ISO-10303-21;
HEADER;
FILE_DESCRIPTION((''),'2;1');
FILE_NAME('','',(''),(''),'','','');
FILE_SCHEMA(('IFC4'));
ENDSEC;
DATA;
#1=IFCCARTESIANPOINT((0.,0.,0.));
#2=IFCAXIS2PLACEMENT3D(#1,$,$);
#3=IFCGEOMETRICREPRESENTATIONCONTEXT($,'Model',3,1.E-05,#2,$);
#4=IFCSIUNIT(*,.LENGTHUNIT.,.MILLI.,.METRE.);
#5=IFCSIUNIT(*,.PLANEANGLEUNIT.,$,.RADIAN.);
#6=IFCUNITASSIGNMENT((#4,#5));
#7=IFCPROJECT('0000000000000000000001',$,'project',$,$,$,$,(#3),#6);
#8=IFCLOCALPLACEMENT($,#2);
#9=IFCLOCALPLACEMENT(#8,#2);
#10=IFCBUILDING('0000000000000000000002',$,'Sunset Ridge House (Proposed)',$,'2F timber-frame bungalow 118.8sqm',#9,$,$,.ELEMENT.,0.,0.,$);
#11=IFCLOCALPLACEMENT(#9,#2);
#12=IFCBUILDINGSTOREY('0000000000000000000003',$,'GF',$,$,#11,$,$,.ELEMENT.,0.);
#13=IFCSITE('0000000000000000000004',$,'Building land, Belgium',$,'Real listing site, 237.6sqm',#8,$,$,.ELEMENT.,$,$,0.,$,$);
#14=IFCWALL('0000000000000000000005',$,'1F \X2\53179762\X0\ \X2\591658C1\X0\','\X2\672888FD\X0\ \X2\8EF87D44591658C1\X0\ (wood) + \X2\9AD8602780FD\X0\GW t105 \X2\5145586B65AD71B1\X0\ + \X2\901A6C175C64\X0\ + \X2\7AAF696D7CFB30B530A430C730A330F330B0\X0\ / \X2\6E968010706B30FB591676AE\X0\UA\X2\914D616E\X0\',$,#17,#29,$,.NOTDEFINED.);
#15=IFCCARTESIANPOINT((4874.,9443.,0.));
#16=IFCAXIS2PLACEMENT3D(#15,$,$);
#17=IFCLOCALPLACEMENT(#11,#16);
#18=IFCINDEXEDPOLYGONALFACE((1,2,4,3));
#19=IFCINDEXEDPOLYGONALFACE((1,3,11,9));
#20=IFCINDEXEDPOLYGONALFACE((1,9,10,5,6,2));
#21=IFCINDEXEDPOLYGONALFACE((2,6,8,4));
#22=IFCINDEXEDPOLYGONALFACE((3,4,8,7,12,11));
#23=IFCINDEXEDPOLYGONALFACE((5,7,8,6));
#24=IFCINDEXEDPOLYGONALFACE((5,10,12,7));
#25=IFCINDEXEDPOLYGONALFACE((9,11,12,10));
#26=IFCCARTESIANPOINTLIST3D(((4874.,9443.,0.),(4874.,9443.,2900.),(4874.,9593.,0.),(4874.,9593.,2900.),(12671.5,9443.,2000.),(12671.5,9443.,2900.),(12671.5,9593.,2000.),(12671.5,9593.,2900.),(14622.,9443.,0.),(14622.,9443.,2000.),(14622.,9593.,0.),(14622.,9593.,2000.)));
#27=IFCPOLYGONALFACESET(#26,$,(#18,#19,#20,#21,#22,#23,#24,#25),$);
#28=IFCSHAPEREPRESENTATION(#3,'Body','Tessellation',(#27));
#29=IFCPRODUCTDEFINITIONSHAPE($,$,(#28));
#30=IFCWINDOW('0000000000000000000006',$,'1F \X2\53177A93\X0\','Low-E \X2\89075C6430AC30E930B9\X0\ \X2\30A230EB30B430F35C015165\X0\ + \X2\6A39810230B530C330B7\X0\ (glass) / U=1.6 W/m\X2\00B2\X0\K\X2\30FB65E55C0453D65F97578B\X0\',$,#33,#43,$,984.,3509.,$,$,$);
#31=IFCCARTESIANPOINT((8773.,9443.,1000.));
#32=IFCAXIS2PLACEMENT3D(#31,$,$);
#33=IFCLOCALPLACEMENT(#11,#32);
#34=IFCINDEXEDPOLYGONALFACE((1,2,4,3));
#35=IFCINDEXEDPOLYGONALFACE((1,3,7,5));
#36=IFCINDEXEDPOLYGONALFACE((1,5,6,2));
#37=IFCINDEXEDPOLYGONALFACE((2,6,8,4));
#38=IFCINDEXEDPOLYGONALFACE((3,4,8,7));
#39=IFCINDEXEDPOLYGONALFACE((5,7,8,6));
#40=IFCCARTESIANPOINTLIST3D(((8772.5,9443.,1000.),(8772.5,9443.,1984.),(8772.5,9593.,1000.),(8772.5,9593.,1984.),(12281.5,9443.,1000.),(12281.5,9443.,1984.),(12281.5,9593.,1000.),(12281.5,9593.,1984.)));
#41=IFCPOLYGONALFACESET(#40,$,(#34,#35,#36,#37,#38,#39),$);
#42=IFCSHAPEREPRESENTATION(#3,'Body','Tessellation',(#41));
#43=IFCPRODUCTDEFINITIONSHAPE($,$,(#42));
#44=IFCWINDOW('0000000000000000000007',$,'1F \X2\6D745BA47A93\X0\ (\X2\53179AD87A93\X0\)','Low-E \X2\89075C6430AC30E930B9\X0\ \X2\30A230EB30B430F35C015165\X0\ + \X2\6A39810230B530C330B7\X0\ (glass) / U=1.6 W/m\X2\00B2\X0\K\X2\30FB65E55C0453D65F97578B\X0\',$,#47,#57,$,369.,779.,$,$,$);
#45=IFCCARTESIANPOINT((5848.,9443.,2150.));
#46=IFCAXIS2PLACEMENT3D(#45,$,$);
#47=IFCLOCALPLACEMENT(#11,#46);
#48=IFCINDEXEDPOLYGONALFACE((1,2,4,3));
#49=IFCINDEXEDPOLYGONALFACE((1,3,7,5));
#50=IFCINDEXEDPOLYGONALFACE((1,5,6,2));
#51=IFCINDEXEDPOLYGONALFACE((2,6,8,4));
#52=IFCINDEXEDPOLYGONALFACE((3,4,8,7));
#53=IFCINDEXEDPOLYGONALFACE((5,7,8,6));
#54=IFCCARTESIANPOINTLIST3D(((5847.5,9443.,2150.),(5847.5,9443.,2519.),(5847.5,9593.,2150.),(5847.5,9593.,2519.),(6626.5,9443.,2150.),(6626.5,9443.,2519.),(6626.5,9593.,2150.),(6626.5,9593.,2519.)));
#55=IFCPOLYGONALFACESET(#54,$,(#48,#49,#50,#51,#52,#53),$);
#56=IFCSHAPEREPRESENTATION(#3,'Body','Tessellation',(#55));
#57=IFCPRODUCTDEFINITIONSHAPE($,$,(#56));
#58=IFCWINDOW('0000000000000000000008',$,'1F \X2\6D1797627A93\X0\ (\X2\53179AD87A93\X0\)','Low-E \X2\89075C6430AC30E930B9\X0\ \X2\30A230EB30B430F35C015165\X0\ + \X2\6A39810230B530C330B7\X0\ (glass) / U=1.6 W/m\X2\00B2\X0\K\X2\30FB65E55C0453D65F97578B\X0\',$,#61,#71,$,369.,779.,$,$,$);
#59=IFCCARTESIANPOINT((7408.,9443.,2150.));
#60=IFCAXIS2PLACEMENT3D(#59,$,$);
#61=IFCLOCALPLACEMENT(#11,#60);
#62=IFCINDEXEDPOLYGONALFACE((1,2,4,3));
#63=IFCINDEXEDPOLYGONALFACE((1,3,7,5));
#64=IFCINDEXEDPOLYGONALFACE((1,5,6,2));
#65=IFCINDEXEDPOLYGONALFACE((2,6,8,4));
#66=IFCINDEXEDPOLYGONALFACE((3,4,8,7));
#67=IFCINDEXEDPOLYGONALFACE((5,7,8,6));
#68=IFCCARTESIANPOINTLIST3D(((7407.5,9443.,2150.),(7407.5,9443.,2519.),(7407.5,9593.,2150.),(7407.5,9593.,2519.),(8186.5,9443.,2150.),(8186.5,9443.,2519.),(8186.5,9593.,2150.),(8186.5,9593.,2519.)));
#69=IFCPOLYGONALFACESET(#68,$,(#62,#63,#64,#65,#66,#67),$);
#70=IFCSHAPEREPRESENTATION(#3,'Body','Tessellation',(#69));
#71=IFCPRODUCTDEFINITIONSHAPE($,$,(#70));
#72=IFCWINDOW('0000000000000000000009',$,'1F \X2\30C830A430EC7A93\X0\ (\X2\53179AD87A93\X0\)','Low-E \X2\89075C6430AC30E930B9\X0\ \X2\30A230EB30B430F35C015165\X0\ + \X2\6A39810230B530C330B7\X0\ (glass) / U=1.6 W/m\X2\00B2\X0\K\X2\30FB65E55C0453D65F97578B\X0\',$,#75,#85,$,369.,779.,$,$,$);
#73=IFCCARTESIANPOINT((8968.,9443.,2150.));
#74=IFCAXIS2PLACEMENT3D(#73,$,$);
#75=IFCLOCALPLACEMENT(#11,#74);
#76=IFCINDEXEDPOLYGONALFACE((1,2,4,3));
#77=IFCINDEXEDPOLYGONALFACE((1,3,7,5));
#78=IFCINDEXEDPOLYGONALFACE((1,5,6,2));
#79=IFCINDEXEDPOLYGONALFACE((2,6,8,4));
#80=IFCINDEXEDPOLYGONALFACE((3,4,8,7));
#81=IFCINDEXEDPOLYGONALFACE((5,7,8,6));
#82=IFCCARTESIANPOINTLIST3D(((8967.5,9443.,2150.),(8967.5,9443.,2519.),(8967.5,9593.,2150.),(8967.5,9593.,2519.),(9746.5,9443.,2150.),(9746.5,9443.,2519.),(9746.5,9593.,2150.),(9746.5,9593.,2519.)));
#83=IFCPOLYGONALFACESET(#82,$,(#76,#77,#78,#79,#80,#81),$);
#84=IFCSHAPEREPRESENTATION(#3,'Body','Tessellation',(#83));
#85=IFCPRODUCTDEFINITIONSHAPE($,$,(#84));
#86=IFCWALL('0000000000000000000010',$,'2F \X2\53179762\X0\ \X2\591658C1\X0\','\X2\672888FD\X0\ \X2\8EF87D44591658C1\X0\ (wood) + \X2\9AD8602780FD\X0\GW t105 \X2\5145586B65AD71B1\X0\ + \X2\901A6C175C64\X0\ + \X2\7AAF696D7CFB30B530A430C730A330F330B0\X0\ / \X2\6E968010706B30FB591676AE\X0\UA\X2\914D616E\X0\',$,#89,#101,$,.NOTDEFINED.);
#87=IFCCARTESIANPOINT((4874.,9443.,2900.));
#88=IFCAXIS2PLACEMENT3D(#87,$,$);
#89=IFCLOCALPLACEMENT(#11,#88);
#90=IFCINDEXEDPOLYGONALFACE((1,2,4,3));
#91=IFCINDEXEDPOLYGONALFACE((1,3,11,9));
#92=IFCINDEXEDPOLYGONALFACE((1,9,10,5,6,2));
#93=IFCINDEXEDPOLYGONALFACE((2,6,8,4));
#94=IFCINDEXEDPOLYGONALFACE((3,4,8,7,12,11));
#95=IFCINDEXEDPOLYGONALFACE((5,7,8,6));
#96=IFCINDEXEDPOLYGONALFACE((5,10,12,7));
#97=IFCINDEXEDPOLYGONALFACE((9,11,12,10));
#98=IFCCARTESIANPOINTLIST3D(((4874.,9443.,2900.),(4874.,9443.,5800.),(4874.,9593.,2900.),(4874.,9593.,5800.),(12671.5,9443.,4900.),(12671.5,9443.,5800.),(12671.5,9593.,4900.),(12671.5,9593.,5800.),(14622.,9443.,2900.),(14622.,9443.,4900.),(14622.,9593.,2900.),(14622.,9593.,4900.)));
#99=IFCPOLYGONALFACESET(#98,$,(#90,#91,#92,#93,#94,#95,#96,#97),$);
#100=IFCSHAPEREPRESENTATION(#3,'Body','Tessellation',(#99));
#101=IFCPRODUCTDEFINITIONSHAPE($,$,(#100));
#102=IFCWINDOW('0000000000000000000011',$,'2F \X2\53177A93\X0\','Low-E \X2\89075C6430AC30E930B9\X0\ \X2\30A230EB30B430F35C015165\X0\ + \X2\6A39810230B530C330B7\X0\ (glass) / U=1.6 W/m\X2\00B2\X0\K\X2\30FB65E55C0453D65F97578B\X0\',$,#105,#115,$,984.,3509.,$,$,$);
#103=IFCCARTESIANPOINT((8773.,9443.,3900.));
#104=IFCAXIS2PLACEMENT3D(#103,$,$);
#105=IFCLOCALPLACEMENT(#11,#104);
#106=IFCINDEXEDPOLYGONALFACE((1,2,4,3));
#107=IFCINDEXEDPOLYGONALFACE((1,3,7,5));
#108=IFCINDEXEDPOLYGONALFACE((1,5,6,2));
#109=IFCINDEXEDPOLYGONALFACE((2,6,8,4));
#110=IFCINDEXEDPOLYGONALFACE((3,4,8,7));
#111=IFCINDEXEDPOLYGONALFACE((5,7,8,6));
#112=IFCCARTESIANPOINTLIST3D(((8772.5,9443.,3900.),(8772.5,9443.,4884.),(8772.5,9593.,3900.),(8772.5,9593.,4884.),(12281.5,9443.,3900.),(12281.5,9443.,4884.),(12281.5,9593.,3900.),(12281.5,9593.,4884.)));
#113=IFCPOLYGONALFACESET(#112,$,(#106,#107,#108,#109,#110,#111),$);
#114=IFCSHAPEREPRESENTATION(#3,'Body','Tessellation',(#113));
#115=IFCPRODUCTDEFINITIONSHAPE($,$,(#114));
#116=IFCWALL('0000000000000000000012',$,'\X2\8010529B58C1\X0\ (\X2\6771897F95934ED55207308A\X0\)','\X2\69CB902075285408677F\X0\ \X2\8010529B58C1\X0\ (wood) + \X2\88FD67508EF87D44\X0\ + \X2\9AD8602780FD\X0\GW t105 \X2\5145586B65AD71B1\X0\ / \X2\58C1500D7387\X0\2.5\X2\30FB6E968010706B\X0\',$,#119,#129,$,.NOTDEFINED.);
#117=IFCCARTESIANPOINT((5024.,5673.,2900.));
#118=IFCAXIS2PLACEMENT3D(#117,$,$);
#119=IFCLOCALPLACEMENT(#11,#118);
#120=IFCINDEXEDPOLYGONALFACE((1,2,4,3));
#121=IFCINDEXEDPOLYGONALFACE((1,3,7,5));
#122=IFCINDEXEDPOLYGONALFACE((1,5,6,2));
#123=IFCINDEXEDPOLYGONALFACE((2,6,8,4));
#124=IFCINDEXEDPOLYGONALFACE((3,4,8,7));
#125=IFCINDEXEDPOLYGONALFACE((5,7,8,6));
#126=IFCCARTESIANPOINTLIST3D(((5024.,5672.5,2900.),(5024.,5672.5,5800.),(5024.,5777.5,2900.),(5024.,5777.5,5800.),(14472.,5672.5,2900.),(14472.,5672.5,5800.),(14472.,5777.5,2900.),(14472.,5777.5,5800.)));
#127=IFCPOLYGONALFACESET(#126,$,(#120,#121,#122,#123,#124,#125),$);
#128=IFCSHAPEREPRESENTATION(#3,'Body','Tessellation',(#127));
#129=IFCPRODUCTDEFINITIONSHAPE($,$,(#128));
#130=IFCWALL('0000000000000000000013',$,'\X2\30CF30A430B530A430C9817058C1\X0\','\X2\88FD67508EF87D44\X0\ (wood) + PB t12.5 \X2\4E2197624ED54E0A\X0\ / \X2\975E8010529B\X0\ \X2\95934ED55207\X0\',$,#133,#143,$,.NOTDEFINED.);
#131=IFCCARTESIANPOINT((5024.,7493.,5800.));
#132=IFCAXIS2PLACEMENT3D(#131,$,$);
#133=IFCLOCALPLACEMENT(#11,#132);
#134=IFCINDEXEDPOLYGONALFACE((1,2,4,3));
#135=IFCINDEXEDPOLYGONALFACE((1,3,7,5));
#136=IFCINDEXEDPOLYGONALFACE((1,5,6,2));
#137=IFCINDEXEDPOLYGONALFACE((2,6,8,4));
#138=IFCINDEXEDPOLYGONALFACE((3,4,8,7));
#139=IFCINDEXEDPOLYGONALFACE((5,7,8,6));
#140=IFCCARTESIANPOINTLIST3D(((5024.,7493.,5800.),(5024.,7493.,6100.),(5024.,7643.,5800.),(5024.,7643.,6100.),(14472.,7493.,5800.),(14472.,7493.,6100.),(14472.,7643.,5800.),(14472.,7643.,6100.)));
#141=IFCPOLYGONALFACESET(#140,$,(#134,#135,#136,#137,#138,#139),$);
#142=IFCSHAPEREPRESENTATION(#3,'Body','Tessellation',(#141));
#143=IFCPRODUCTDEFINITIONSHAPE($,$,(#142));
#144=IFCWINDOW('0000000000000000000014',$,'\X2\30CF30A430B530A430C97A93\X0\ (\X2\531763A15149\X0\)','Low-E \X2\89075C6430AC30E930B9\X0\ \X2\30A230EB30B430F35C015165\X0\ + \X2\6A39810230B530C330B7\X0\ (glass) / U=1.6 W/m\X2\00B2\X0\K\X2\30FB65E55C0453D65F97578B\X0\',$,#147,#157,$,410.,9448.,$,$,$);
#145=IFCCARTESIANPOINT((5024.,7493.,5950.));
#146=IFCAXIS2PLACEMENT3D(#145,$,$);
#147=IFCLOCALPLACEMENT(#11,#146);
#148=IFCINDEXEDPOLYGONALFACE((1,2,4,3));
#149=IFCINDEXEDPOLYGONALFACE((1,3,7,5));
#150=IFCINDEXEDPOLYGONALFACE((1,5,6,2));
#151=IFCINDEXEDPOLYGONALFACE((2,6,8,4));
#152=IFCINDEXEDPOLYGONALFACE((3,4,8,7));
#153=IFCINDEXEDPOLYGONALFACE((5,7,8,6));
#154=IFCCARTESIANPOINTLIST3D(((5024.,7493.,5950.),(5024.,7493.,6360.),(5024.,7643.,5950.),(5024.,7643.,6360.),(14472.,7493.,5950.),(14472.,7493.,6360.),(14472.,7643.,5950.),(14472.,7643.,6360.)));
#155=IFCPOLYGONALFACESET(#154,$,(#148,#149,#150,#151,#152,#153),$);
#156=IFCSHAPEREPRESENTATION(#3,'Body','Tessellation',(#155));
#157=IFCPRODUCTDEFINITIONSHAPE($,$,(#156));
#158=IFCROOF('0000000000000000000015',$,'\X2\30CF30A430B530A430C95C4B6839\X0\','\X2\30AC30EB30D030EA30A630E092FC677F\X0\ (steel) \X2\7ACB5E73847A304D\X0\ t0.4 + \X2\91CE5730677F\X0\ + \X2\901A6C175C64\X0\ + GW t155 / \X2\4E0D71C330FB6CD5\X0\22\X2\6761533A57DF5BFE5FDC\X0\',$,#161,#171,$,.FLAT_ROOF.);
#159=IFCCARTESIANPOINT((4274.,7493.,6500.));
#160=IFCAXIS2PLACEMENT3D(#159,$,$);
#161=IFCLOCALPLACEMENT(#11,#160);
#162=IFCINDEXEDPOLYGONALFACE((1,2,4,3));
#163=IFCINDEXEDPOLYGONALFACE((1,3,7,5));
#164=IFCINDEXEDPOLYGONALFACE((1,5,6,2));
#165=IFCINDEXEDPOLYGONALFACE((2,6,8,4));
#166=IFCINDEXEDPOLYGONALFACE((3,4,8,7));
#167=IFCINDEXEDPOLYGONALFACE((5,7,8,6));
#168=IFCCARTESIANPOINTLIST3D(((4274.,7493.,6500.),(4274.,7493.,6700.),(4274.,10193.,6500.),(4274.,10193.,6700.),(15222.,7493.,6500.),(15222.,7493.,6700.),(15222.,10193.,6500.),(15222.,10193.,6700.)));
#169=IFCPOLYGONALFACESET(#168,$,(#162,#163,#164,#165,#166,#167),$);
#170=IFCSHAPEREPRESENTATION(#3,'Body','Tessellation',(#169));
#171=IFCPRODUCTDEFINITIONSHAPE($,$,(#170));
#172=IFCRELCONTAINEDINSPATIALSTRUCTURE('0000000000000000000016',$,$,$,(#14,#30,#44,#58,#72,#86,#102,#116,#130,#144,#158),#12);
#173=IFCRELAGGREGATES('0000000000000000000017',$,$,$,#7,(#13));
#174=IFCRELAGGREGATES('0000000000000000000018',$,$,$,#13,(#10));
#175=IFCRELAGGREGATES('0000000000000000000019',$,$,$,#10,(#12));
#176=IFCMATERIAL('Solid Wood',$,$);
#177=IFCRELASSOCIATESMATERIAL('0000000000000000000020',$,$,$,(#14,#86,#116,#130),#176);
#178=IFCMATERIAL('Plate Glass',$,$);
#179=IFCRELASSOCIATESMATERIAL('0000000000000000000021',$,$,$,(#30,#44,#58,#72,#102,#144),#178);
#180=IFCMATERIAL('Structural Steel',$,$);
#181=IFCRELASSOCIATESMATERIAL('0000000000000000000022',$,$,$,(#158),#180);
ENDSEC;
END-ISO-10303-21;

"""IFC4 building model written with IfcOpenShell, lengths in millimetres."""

from ifc_helpers import new_model, si_unit, frame, frame_2d, origin, place, context, project, spatial, rectangle, extrude, material, element, fill, save


model = new_model("IFC4")

# Units and contexts
model_context = context("Model", 3, precision=1e-05, world=origin())
ifc_project = project(units=[si_unit("LENGTHUNIT", "METRE", prefix="MILLI"), si_unit("PLANEANGLEUNIT", "RADIAN")], contexts=[model_context])

# Site, building, storey
site_placement = place(None, origin())
site = spatial("IfcSite", under=ifc_project, at=site_placement, Name="Building land, Belgium", ObjectType="Real listing site, 237.6sqm", CompositionType="ELEMENT", RefElevation=0.0)
building_placement = place(site_placement, origin())
building = spatial("IfcBuilding", under=site, at=building_placement, Name="Sunset Ridge House (Proposed)", ObjectType="2F timber-frame bungalow 118.8sqm", CompositionType="ELEMENT", ElevationOfRefHeight=0.0, ElevationOfTerrain=0.0)
storey_placement = place(building_placement, origin())
storey = spatial("IfcBuildingStorey", under=building, at=storey_placement, Name="GF", CompositionType="ELEMENT", Elevation=0.0)

# Wall, openings, windows
ifc_material_1 = material(Name="Solid Wood")
wall_1_placement = place(storey_placement, frame((4874.0, 9443.0, 0.0)))
wall_1 = element("IfcWall", 1, at=wall_1_placement, inside=storey, material=ifc_material_1, Name="1F 北面 外壁", Description="木製 軸組外壁 (wood) + 高性能GW t105 充填断熱 + 通気層 + 窯業系サイディング / 準耐火・外皮UA配慮", PredefinedType="NOTDEFINED", context=model_context, shape_type="SweptSolid", body=[
    extrude(rectangle(XDim=9748.0, YDim=150.0, at=frame_2d((4874.0, 75.0))), frame((4874.0, 9443.0, 0.0)), (0.0, 0.0, 1.0), 2900.0),
])
opening_1_placement = place(storey_placement, frame((8773.0, 9443.0, 1000.0)))
opening_1 = element("IfcOpeningElement", 2, at=opening_1_placement, cuts=wall_1, PredefinedType="NOTDEFINED", context=model_context, shape_type="SweptSolid", body=[
    extrude(rectangle(XDim=3509.0, YDim=150.0, at=frame_2d((1754.0, 75.0))), frame((8773.0, 9443.0, 1000.0)), (0.0, 0.0, 1.0), 984.0),
])
opening_2_placement = place(storey_placement, frame((5848.0, 9443.0, 2150.0)))
opening_2 = element("IfcOpeningElement", 3, at=opening_2_placement, cuts=wall_1, PredefinedType="NOTDEFINED", context=model_context, shape_type="SweptSolid", body=[
    extrude(rectangle(XDim=779.0, YDim=150.0, at=frame_2d((389.0, 75.0))), frame((5848.0, 9443.0, 2150.0)), (0.0, 0.0, 1.0), 369.0),
])
opening_3_placement = place(storey_placement, frame((7408.0, 9443.0, 2150.0)))
opening_3 = element("IfcOpeningElement", 4, at=opening_3_placement, cuts=wall_1, PredefinedType="NOTDEFINED", context=model_context, shape_type="SweptSolid", body=[
    extrude(rectangle(XDim=779.0, YDim=150.0, at=frame_2d((389.0, 75.0))), frame((7408.0, 9443.0, 2150.0)), (0.0, 0.0, 1.0), 369.0),
])
opening_4_placement = place(storey_placement, frame((8968.0, 9443.0, 2150.0)))
opening_4 = element("IfcOpeningElement", 5, at=opening_4_placement, cuts=wall_1, PredefinedType="NOTDEFINED", context=model_context, shape_type="SweptSolid", body=[
    extrude(rectangle(XDim=779.0, YDim=150.0, at=frame_2d((389.0, 75.0))), frame((8968.0, 9443.0, 2150.0)), (0.0, 0.0, 1.0), 369.0),
])
ifc_material_2 = material(Name="Plate Glass")
window_1_placement = place(storey_placement, frame((8773.0, 9443.0, 1000.0)))
window_1 = element("IfcWindow", 6, at=window_1_placement, inside=storey, material=ifc_material_2, Name="1F 北窓", Description="Low-E 複層ガラス アルゴン封入 + 樹脂サッシ (glass) / U=1.6 W/m²K・日射取得型", OverallHeight=984.0, OverallWidth=3509.0, context=model_context, shape_type="SweptSolid", body=[
    extrude(rectangle(XDim=3509.0, YDim=150.0, at=frame_2d((1754.0, 75.0))), frame((8773.0, 9443.0, 1000.0)), (0.0, 0.0, 1.0), 984.0),
])
fill(opening_1, window_1)
window_2_placement = place(storey_placement, frame((5848.0, 9443.0, 2150.0)))
window_2 = element("IfcWindow", 7, at=window_2_placement, inside=storey, material=ifc_material_2, Name="1F 浴室窓 (北高窓)", Description="Low-E 複層ガラス アルゴン封入 + 樹脂サッシ (glass) / U=1.6 W/m²K・日射取得型", OverallHeight=369.0, OverallWidth=779.0, context=model_context, shape_type="SweptSolid", body=[
    extrude(rectangle(XDim=779.0, YDim=150.0, at=frame_2d((389.0, 75.0))), frame((5848.0, 9443.0, 2150.0)), (0.0, 0.0, 1.0), 369.0),
])
fill(opening_2, window_2)
window_3_placement = place(storey_placement, frame((7408.0, 9443.0, 2150.0)))
window_3 = element("IfcWindow", 8, at=window_3_placement, inside=storey, material=ifc_material_2, Name="1F 洗面窓 (北高窓)", Description="Low-E 複層ガラス アルゴン封入 + 樹脂サッシ (glass) / U=1.6 W/m²K・日射取得型", OverallHeight=369.0, OverallWidth=779.0, context=model_context, shape_type="SweptSolid", body=[
    extrude(rectangle(XDim=779.0, YDim=150.0, at=frame_2d((389.0, 75.0))), frame((7408.0, 9443.0, 2150.0)), (0.0, 0.0, 1.0), 369.0),
])
fill(opening_3, window_3)
window_4_placement = place(storey_placement, frame((8968.0, 9443.0, 2150.0)))
window_4 = element("IfcWindow", 9, at=window_4_placement, inside=storey, material=ifc_material_2, Name="1F トイレ窓 (北高窓)", Description="Low-E 複層ガラス アルゴン封入 + 樹脂サッシ (glass) / U=1.6 W/m²K・日射取得型", OverallHeight=369.0, OverallWidth=779.0, context=model_context, shape_type="SweptSolid", body=[
    extrude(rectangle(XDim=779.0, YDim=150.0, at=frame_2d((389.0, 75.0))), frame((8968.0, 9443.0, 2150.0)), (0.0, 0.0, 1.0), 369.0),
])
fill(opening_4, window_4)

# Wall, opening, window
wall_2_placement = place(storey_placement, frame((4874.0, 9443.0, 2900.0)))
wall_2 = element("IfcWall", 10, at=wall_2_placement, inside=storey, material=ifc_material_1, Name="2F 北面 外壁", Description="木製 軸組外壁 (wood) + 高性能GW t105 充填断熱 + 通気層 + 窯業系サイディング / 準耐火・外皮UA配慮", PredefinedType="NOTDEFINED", context=model_context, shape_type="SweptSolid", body=[
    extrude(rectangle(XDim=9748.0, YDim=150.0, at=frame_2d((4874.0, 75.0))), frame((4874.0, 9443.0, 2900.0)), (0.0, 0.0, 1.0), 2900.0),
])
opening_5_placement = place(storey_placement, frame((8773.0, 9443.0, 3900.0)))
opening_5 = element("IfcOpeningElement", 11, at=opening_5_placement, cuts=wall_2, PredefinedType="NOTDEFINED", context=model_context, shape_type="SweptSolid", body=[
    extrude(rectangle(XDim=3509.0, YDim=150.0, at=frame_2d((1754.0, 75.0))), frame((8773.0, 9443.0, 3900.0)), (0.0, 0.0, 1.0), 984.0),
])
window_5_placement = place(storey_placement, frame((8773.0, 9443.0, 3900.0)))
window_5 = element("IfcWindow", 12, at=window_5_placement, inside=storey, material=ifc_material_2, Name="2F 北窓", Description="Low-E 複層ガラス アルゴン封入 + 樹脂サッシ (glass) / U=1.6 W/m²K・日射取得型", OverallHeight=984.0, OverallWidth=3509.0, context=model_context, shape_type="SweptSolid", body=[
    extrude(rectangle(XDim=3509.0, YDim=150.0, at=frame_2d((1754.0, 75.0))), frame((8773.0, 9443.0, 3900.0)), (0.0, 0.0, 1.0), 984.0),
])
fill(opening_5, window_5)

# Wall
wall_3_placement = place(storey_placement, frame((5024.0, 5673.0, 2900.0)))
element("IfcWall", 13, at=wall_3_placement, inside=storey, material=ifc_material_1, Name="耐力壁 (東西間仕切り)", Description="構造用合板 耐力壁 (wood) + 製材軸組 + 高性能GW t105 充填断熱 / 壁倍率2.5・準耐火", PredefinedType="NOTDEFINED", context=model_context, shape_type="SweptSolid", body=[
    extrude(rectangle(XDim=9448.0, YDim=105.0, at=frame_2d((4724.0, 52.0))), frame((5024.0, 5673.0, 2900.0)), (0.0, 0.0, 1.0), 2900.0),
])

# Wall, opening, window
wall_4_placement = place(storey_placement, frame((5024.0, 7493.0, 5800.0)))
wall_4 = element("IfcWall", 14, at=wall_4_placement, inside=storey, material=ifc_material_1, Name="ハイサイド腰壁", Description="製材軸組 (wood) + PB t12.5 両面仕上 / 非耐力 間仕切", PredefinedType="NOTDEFINED", context=model_context, shape_type="SweptSolid", body=[
    extrude(rectangle(XDim=9448.0, YDim=150.0, at=frame_2d((4724.0, 75.0))), frame((5024.0, 7493.0, 5800.0)), (0.0, 0.0, 1.0), 700.0),
])
opening_6_placement = place(storey_placement, frame((5024.0, 7493.0, 5950.0)))
opening_6 = element("IfcOpeningElement", 15, at=opening_6_placement, cuts=wall_4, PredefinedType="NOTDEFINED", context=model_context, shape_type="SweptSolid", body=[
    extrude(rectangle(XDim=9448.0, YDim=150.0, at=frame_2d((4724.0, 75.0))), frame((5024.0, 7493.0, 5950.0)), (0.0, 0.0, 1.0), 410.0),
])
window_6_placement = place(storey_placement, frame((5024.0, 7493.0, 5950.0)))
window_6 = element("IfcWindow", 16, at=window_6_placement, inside=storey, material=ifc_material_2, Name="ハイサイド窓 (北採光)", Description="Low-E 複層ガラス アルゴン封入 + 樹脂サッシ (glass) / U=1.6 W/m²K・日射取得型", OverallHeight=410.0, OverallWidth=9448.0, context=model_context, shape_type="SweptSolid", body=[
    extrude(rectangle(XDim=9448.0, YDim=150.0, at=frame_2d((4724.0, 75.0))), frame((5024.0, 7493.0, 5950.0)), (0.0, 0.0, 1.0), 410.0),
])
fill(opening_6, window_6)

# Roof
ifc_material_3 = material(Name="Structural Steel")
roof_placement = place(storey_placement, frame((4274.0, 7493.0, 6500.0)))
element("IfcRoof", 17, at=roof_placement, inside=storey, material=ifc_material_3, Name="ハイサイド屋根", Description="ガルバリウム鋼板 (steel) 立平葺き t0.4 + 野地板 + 通気層 + GW t155 / 不燃・法22条区域対応", PredefinedType="FLAT_ROOF", context=model_context, shape_type="SweptSolid", body=[
    extrude(rectangle(XDim=10948.0, YDim=2700.0, at=frame_2d((5474.0, 1350.0))), frame((4274.0, 7493.0, 6500.0)), (0.0, 0.0, 1.0), 200.0),
])

save(model, "model.ifc")
